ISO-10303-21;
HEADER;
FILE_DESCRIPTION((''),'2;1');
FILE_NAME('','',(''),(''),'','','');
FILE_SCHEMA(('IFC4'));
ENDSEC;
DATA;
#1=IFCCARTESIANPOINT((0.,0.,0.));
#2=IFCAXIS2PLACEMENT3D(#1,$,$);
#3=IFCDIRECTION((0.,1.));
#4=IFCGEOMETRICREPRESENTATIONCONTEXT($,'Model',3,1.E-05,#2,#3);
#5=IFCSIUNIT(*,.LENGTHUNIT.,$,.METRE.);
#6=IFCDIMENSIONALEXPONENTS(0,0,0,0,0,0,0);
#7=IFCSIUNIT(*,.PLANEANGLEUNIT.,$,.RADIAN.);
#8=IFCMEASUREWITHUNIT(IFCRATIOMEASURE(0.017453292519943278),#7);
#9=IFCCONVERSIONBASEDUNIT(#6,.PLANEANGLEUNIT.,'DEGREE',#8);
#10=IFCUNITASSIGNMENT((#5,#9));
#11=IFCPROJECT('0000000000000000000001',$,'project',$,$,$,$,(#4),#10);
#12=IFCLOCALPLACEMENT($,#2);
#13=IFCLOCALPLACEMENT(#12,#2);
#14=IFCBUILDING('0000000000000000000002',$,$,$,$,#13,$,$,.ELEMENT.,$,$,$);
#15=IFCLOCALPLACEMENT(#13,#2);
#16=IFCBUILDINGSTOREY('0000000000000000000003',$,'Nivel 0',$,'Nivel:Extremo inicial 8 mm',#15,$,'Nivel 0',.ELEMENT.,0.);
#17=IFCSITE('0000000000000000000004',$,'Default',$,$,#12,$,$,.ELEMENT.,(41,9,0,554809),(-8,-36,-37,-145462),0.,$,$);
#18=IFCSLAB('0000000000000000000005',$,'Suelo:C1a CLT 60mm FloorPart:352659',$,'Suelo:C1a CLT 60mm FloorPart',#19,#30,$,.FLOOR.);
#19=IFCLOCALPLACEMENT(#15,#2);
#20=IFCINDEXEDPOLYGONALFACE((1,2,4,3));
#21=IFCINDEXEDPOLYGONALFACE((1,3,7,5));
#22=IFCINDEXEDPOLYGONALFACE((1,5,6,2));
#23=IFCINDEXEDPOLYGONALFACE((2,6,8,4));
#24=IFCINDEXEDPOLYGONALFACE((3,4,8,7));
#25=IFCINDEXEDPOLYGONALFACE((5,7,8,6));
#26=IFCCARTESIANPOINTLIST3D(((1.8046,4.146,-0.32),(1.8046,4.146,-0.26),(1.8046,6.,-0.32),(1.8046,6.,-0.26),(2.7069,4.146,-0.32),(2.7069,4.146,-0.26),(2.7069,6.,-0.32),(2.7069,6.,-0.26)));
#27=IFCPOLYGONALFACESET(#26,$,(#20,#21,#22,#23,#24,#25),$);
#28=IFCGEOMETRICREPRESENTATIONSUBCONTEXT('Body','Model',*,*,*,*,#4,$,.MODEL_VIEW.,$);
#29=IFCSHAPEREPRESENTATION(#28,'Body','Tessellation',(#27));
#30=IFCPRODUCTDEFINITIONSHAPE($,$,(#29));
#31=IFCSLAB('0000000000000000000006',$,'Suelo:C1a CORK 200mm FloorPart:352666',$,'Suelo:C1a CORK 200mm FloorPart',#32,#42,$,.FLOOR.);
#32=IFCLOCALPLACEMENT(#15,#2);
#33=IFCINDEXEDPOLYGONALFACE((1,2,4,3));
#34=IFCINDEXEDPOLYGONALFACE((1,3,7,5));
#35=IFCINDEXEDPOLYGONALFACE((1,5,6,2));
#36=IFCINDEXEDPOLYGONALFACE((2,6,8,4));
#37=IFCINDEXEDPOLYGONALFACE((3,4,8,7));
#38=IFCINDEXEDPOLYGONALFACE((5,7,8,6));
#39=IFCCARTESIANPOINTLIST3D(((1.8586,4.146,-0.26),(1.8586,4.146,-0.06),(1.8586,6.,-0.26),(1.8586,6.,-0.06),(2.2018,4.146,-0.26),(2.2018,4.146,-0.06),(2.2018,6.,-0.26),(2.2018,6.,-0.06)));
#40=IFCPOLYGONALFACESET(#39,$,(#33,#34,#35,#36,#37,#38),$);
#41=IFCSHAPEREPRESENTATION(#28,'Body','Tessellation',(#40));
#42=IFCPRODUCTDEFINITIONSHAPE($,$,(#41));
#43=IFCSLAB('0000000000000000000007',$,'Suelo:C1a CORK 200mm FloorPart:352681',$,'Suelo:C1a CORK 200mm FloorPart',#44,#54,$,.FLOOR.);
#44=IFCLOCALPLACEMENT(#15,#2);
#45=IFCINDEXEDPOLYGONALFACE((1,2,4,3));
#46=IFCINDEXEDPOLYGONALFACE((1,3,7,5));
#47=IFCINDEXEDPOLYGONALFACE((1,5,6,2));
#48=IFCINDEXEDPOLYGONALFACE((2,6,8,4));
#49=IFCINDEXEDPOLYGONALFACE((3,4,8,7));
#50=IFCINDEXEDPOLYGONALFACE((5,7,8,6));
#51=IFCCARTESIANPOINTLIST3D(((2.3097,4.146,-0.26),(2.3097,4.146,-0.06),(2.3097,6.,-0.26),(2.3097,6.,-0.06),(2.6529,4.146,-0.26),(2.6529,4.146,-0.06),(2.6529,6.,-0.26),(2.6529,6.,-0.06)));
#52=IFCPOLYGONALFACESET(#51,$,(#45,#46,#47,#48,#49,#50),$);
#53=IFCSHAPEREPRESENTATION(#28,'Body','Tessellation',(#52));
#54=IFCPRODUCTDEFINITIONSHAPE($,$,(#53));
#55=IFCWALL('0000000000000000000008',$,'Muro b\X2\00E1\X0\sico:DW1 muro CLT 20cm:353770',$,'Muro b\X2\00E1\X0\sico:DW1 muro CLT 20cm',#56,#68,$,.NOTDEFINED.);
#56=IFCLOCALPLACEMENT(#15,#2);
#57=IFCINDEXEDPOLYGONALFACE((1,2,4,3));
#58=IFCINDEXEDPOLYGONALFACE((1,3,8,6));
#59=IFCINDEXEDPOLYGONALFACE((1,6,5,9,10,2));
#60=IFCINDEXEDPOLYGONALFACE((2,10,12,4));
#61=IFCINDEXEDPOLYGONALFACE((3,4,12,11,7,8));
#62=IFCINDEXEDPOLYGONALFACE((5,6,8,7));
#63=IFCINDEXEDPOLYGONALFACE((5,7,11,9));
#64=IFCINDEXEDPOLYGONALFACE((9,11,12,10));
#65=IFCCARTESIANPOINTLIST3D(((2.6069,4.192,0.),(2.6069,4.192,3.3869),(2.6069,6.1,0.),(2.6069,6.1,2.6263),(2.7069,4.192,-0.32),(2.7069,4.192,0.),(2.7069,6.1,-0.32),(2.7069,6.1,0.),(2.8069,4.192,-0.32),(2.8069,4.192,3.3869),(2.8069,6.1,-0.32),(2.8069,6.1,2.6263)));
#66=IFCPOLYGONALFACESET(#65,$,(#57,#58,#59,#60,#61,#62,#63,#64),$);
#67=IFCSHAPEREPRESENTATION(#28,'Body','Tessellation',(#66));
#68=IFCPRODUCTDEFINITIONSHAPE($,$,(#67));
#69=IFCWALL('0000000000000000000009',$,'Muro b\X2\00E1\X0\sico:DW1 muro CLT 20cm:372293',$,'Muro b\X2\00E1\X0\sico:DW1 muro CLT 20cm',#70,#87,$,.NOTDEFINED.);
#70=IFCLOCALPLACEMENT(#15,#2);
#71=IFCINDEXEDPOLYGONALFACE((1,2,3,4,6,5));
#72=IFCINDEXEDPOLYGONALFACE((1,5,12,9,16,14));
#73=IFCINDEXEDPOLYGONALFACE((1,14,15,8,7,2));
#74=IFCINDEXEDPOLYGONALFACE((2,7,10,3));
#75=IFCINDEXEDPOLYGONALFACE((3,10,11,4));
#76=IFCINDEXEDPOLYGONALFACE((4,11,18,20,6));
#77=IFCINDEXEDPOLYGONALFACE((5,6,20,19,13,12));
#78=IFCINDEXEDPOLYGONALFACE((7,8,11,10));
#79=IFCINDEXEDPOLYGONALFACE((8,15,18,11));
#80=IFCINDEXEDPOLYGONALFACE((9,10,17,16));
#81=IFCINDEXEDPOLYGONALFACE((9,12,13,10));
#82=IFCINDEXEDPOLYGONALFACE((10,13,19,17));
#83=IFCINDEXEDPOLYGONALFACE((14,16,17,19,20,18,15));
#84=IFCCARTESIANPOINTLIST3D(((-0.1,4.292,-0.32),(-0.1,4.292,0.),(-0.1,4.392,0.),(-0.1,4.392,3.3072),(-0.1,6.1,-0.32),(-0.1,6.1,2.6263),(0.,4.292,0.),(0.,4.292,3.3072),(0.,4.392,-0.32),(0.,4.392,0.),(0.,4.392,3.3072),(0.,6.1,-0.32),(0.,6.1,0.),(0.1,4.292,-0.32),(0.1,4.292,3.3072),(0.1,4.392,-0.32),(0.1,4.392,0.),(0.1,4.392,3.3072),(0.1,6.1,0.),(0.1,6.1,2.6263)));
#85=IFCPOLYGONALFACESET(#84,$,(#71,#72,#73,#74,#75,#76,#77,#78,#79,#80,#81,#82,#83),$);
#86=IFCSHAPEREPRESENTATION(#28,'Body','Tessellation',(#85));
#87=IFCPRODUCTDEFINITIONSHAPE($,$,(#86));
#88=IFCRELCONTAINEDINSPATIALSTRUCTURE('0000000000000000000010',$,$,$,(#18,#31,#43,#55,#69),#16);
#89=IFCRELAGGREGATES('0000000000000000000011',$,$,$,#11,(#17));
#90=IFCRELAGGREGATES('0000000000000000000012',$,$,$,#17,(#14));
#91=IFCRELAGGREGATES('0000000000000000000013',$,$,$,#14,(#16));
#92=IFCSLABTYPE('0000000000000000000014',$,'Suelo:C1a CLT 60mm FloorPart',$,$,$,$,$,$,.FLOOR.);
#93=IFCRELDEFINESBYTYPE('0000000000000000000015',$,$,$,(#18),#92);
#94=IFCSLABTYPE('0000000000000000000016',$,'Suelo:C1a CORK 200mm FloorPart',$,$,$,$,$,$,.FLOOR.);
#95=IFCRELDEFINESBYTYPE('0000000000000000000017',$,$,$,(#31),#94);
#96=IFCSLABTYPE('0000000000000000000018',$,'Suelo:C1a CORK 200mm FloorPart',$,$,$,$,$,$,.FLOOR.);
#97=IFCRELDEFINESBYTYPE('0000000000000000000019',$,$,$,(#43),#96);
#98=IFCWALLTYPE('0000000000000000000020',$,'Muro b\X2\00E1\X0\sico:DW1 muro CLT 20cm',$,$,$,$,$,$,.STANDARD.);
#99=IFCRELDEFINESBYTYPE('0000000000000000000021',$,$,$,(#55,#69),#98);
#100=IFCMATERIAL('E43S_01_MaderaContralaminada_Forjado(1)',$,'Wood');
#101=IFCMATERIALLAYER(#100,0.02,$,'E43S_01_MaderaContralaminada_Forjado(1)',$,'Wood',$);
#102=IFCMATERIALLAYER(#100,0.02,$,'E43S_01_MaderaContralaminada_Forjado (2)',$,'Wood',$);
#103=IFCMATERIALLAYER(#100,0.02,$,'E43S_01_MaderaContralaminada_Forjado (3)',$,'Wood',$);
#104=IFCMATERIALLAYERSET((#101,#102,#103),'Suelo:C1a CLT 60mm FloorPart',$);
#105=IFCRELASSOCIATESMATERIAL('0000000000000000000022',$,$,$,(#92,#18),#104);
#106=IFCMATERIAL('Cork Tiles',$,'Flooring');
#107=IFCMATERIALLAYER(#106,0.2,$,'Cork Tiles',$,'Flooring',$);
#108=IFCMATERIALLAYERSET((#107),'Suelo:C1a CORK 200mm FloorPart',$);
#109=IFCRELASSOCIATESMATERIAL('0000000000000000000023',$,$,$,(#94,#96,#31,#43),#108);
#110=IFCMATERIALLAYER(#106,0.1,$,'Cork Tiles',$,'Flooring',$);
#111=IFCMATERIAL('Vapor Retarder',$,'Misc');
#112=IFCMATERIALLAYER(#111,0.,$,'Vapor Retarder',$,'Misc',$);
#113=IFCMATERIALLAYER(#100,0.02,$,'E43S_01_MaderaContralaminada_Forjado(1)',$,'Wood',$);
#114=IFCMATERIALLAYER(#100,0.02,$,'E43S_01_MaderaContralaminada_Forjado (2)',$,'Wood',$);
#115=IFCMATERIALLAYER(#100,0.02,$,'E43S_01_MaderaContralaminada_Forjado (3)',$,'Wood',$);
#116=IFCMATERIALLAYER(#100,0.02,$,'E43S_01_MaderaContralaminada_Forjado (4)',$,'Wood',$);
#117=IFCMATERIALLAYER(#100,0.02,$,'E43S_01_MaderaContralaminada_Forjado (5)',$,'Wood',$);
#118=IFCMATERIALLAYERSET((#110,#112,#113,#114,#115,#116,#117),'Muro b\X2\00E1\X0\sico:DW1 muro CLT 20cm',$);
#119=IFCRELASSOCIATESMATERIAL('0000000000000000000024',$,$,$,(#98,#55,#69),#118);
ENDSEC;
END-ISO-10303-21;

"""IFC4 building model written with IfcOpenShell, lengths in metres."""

from ifc_helpers import new_model, entity, si_unit, converted_unit, direction, frame, frame_2d, origin, origin_2d_with_axis, place, context, subcontext, project, spatial, polyline, rectangle, extrude, clip, bounded_halfspace, material, layer, layer_set, layer_usage, type_object, element, save


model = new_model("IFC4")

# Units and contexts
model_context = context("Model", 3, precision=1e-05, world=origin(), true_north=direction((0.0, 1.0)))
body_context = subcontext(model_context, "Body", "Model", "MODEL_VIEW")
ifc_project = project(units=[si_unit("LENGTHUNIT", "METRE"), converted_unit("PLANEANGLEUNIT", "DEGREE", entity("IfcRatioMeasure", 0.017453292519943278), si_unit("PLANEANGLEUNIT", "RADIAN"), dimensions=[0, 0, 0, 0, 0, 0, 0])], contexts=[model_context])

# Site, building, storey
site_placement = place(None, origin())
site = spatial("IfcSite", under=ifc_project, at=site_placement, Name="Default", CompositionType="ELEMENT", RefLatitude=(41, 9, 0, 554809), RefLongitude=(-8, -36, -37, -145462), RefElevation=0.0)
building_placement = place(site_placement, origin())
building = spatial("IfcBuilding", under=site, at=building_placement, CompositionType="ELEMENT")
storey_placement = place(building_placement, origin())
storey = spatial("IfcBuildingStorey", under=building, at=storey_placement, Name="Nivel 0", ObjectType="Nivel:Extremo inicial 8 mm", LongName="Nivel 0", CompositionType="ELEMENT", Elevation=0.0)

# Slabs
ifc_material_1 = material(Name="E43S_01_MaderaContralaminada_Forjado(1)", Category="Wood")
ifc_layer_1 = layer(ifc_material_1, 0.02, Name="E43S_01_MaderaContralaminada_Forjado(1)", Category="Wood")
ifc_layer_2 = layer(ifc_material_1, 0.02, Name="E43S_01_MaderaContralaminada_Forjado (2)", Category="Wood")
ifc_layer_3 = layer(ifc_material_1, 0.02, Name="E43S_01_MaderaContralaminada_Forjado (3)", Category="Wood")
ifc_layer_set_1 = layer_set([ifc_layer_1, ifc_layer_2, ifc_layer_3], Name="Suelo:C1a CLT 60mm FloorPart")
ifc_material_2 = material(Name="Cork Tiles", Category="Flooring")
ifc_layer_4 = layer(ifc_material_2, 0.2, Name="Cork Tiles", Category="Flooring")
ifc_layer_set_2 = layer_set([ifc_layer_4], Name="Suelo:C1a CORK 200mm FloorPart")
ifc_layer_usage_1 = layer_usage(ifc_layer_set_1, "AXIS3", "POSITIVE", 0.0)
slab_type_1 = type_object("IfcSlabType", Name="Suelo:C1a CLT 60mm FloorPart", PredefinedType="FLOOR", material=ifc_layer_set_1)
slab_1_placement = place(storey_placement, origin())
element("IfcSlab", 1, at=slab_1_placement, inside=storey, type_object=slab_type_1, material=ifc_layer_usage_1, Name="Suelo:C1a CLT 60mm FloorPart:352659", ObjectType="Suelo:C1a CLT 60mm FloorPart", PredefinedType="FLOOR", context=body_context, shape_type="SweptSolid", body=[
    extrude(rectangle(XDim=1.854, YDim=0.9023, at=frame_2d((0.0, 0.0), x_axis=(1.0, 0.0))), frame((2.2558, 5.073, -0.26), z_axis=(0.0, 0.0, -1.0), x_axis=(0.0, 1.0, 0.0)), (0.0, 0.0, 1.0), 0.06),
])
ifc_layer_usage_2 = layer_usage(ifc_layer_set_2, "AXIS3", "POSITIVE", 0.0)
slab_type_2 = type_object("IfcSlabType", Name="Suelo:C1a CORK 200mm FloorPart", PredefinedType="FLOOR", material=ifc_layer_set_2)
slab_2_placement = place(storey_placement, origin())
element("IfcSlab", 2, at=slab_2_placement, inside=storey, type_object=slab_type_2, material=ifc_layer_usage_2, Name="Suelo:C1a CORK 200mm FloorPart:352666", ObjectType="Suelo:C1a CORK 200mm FloorPart", PredefinedType="FLOOR", context=body_context, shape_type="SweptSolid", body=[
    extrude(rectangle(XDim=1.854, YDim=0.3432, at=frame_2d((0.0, 0.0), x_axis=(1.0, 0.0))), frame((2.0302, 5.073, -0.06), z_axis=(0.0, 0.0, -1.0), x_axis=(0.0, 1.0, 0.0)), (0.0, 0.0, 1.0), 0.2),
])
ifc_layer_usage_3 = layer_usage(ifc_layer_set_2, "AXIS3", "POSITIVE", 0.0)
slab_type_3 = type_object("IfcSlabType", Name="Suelo:C1a CORK 200mm FloorPart", PredefinedType="FLOOR", material=ifc_layer_set_2)
slab_3_placement = place(storey_placement, origin())
element("IfcSlab", 3, at=slab_3_placement, inside=storey, type_object=slab_type_3, material=ifc_layer_usage_3, Name="Suelo:C1a CORK 200mm FloorPart:352681", ObjectType="Suelo:C1a CORK 200mm FloorPart", PredefinedType="FLOOR", context=body_context, shape_type="SweptSolid", body=[
    extrude(rectangle(XDim=1.854, YDim=0.3432, at=origin_2d_with_axis()), frame((2.4813, 5.073, -0.06), z_axis=(0.0, 0.0, -1.0), x_axis=(0.0, 1.0, 0.0)), (0.0, 0.0, 1.0), 0.2),
])

# Walls
ifc_layer_5 = layer(ifc_material_2, 0.1, Name="Cork Tiles", Category="Flooring")
ifc_material_3 = material(Name="Vapor Retarder", Category="Misc")
ifc_layer_6 = layer(ifc_material_3, 0.0, Name="Vapor Retarder", Category="Misc")
ifc_layer_7 = layer(ifc_material_1, 0.02, Name="E43S_01_MaderaContralaminada_Forjado(1)", Category="Wood")
ifc_layer_8 = layer(ifc_material_1, 0.02, Name="E43S_01_MaderaContralaminada_Forjado (2)", Category="Wood")
ifc_layer_9 = layer(ifc_material_1, 0.02, Name="E43S_01_MaderaContralaminada_Forjado (3)", Category="Wood")
ifc_layer_10 = layer(ifc_material_1, 0.02, Name="E43S_01_MaderaContralaminada_Forjado (4)", Category="Wood")
ifc_layer_11 = layer(ifc_material_1, 0.02, Name="E43S_01_MaderaContralaminada_Forjado (5)", Category="Wood")
ifc_layer_set_3 = layer_set([ifc_layer_5, ifc_layer_6, ifc_layer_7, ifc_layer_8, ifc_layer_9, ifc_layer_10, ifc_layer_11], Name="Muro básico:DW1 muro CLT 20cm")
ifc_layer_usage_4 = layer_usage(ifc_layer_set_3, "AXIS2", "NEGATIVE", 0.1)
wall_type_1 = type_object("IfcWallType", Name="Muro básico:DW1 muro CLT 20cm", PredefinedType="STANDARD", material=ifc_layer_set_3)
wall_1_placement = place(storey_placement, frame((2.7069, 6.1, -0.32), z_axis=(0.0, 0.0, 1.0), x_axis=(0.0, -1.0, 0.0)))
element("IfcWall", 4, at=wall_1_placement, inside=storey, type_object=wall_type_1, material=ifc_layer_usage_4, Name="Muro básico:DW1 muro CLT 20cm:353770", ObjectType="Muro básico:DW1 muro CLT 20cm", PredefinedType="NOTDEFINED", context=body_context, shape_type="Clipping", body=[
    clip(clip(extrude(rectangle(XDim=1.908, YDim=0.2, at=frame_2d((0.954, 0.0), x_axis=(-1.0, 0.0))), origin(), (0.0, 0.0, 1.0), 3.7069), bounded_halfspace(frame((0.0, -0.1, 2.9463), z_axis=(-0.370288, 0.0, 0.928917), x_axis=(0.0, -1.0, 0.0)), False, frame((0.0, -0.1, 2.9463)), polyline([(0.0, 0.0), (0.2, 0.0), (1.708, 0.0), (1.908, 0.0), (1.908, 0.2), (0.0, 0.2), (0.0, 0.0)]))), bounded_halfspace(frame((1.908, -0.1, 0.32), z_axis=(0.0, 0.0, -1.0), x_axis=(0.0, 1.0, 0.0)), False, frame((1.908, -0.1, 0.32)), polyline([(0.0, 0.0), (0.0, 0.1), (-0.1, 0.1), (-1.808, 0.1), (-1.908, 0.1), (-1.908, 0.0), (-1.708, 0.0), (-0.2, 0.0), (0.0, 0.0)]))),
])
ifc_layer_usage_5 = layer_usage(ifc_layer_set_3, "AXIS2", "NEGATIVE", 0.1)
wall_2_placement = place(storey_placement, frame((0.0, 4.292, -0.32), z_axis=(0.0, 0.0, 1.0), x_axis=(0.0, 1.0, 0.0)))
element("IfcWall", 5, at=wall_2_placement, inside=storey, type_object=wall_type_1, material=ifc_layer_usage_5, Name="Muro básico:DW1 muro CLT 20cm:372293", ObjectType="Muro básico:DW1 muro CLT 20cm", PredefinedType="NOTDEFINED", context=body_context, shape_type="Clipping", body=[
    clip(clip(clip(extrude(rectangle(XDim=1.808, YDim=0.2, at=frame_2d((0.904, 0.0), x_axis=(-1.0, 0.0))), origin(), (0.0, 0.0, 1.0), 3.6272), bounded_halfspace(frame((0.1, -0.1, 3.6272), z_axis=(0.370288, 0.0, 0.928917), x_axis=(0.0, 1.0, 0.0)), False, frame((0.1, -0.1, 3.6272)), polyline([(0.0, 0.0), (1.508, 0.0), (1.708, 0.0), (1.708, 0.2), (0.0, 0.2), (0.0, 0.0)]))), bounded_halfspace(frame((1.808, -0.1, 0.32), z_axis=(0.0, 0.0, -1.0), x_axis=(0.0, 1.0, 0.0)), False, frame((1.808, -0.1, 0.32)), polyline([(0.0, 0.0), (0.0, 0.1), (-1.708, 0.1), (-1.708, 0.0), (-0.2, 0.0), (-0.1, 0.0), (0.0, 0.0)]))), bounded_halfspace(frame((0.0, 0.0, 0.32)), False, frame((0.0, 0.0, 0.32)), polyline([(0.0, 0.0), (0.1, 0.0), (0.1, 0.1), (0.0, 0.1), (0.0, 0.0)]))),
])

save(model, "model.ifc")
